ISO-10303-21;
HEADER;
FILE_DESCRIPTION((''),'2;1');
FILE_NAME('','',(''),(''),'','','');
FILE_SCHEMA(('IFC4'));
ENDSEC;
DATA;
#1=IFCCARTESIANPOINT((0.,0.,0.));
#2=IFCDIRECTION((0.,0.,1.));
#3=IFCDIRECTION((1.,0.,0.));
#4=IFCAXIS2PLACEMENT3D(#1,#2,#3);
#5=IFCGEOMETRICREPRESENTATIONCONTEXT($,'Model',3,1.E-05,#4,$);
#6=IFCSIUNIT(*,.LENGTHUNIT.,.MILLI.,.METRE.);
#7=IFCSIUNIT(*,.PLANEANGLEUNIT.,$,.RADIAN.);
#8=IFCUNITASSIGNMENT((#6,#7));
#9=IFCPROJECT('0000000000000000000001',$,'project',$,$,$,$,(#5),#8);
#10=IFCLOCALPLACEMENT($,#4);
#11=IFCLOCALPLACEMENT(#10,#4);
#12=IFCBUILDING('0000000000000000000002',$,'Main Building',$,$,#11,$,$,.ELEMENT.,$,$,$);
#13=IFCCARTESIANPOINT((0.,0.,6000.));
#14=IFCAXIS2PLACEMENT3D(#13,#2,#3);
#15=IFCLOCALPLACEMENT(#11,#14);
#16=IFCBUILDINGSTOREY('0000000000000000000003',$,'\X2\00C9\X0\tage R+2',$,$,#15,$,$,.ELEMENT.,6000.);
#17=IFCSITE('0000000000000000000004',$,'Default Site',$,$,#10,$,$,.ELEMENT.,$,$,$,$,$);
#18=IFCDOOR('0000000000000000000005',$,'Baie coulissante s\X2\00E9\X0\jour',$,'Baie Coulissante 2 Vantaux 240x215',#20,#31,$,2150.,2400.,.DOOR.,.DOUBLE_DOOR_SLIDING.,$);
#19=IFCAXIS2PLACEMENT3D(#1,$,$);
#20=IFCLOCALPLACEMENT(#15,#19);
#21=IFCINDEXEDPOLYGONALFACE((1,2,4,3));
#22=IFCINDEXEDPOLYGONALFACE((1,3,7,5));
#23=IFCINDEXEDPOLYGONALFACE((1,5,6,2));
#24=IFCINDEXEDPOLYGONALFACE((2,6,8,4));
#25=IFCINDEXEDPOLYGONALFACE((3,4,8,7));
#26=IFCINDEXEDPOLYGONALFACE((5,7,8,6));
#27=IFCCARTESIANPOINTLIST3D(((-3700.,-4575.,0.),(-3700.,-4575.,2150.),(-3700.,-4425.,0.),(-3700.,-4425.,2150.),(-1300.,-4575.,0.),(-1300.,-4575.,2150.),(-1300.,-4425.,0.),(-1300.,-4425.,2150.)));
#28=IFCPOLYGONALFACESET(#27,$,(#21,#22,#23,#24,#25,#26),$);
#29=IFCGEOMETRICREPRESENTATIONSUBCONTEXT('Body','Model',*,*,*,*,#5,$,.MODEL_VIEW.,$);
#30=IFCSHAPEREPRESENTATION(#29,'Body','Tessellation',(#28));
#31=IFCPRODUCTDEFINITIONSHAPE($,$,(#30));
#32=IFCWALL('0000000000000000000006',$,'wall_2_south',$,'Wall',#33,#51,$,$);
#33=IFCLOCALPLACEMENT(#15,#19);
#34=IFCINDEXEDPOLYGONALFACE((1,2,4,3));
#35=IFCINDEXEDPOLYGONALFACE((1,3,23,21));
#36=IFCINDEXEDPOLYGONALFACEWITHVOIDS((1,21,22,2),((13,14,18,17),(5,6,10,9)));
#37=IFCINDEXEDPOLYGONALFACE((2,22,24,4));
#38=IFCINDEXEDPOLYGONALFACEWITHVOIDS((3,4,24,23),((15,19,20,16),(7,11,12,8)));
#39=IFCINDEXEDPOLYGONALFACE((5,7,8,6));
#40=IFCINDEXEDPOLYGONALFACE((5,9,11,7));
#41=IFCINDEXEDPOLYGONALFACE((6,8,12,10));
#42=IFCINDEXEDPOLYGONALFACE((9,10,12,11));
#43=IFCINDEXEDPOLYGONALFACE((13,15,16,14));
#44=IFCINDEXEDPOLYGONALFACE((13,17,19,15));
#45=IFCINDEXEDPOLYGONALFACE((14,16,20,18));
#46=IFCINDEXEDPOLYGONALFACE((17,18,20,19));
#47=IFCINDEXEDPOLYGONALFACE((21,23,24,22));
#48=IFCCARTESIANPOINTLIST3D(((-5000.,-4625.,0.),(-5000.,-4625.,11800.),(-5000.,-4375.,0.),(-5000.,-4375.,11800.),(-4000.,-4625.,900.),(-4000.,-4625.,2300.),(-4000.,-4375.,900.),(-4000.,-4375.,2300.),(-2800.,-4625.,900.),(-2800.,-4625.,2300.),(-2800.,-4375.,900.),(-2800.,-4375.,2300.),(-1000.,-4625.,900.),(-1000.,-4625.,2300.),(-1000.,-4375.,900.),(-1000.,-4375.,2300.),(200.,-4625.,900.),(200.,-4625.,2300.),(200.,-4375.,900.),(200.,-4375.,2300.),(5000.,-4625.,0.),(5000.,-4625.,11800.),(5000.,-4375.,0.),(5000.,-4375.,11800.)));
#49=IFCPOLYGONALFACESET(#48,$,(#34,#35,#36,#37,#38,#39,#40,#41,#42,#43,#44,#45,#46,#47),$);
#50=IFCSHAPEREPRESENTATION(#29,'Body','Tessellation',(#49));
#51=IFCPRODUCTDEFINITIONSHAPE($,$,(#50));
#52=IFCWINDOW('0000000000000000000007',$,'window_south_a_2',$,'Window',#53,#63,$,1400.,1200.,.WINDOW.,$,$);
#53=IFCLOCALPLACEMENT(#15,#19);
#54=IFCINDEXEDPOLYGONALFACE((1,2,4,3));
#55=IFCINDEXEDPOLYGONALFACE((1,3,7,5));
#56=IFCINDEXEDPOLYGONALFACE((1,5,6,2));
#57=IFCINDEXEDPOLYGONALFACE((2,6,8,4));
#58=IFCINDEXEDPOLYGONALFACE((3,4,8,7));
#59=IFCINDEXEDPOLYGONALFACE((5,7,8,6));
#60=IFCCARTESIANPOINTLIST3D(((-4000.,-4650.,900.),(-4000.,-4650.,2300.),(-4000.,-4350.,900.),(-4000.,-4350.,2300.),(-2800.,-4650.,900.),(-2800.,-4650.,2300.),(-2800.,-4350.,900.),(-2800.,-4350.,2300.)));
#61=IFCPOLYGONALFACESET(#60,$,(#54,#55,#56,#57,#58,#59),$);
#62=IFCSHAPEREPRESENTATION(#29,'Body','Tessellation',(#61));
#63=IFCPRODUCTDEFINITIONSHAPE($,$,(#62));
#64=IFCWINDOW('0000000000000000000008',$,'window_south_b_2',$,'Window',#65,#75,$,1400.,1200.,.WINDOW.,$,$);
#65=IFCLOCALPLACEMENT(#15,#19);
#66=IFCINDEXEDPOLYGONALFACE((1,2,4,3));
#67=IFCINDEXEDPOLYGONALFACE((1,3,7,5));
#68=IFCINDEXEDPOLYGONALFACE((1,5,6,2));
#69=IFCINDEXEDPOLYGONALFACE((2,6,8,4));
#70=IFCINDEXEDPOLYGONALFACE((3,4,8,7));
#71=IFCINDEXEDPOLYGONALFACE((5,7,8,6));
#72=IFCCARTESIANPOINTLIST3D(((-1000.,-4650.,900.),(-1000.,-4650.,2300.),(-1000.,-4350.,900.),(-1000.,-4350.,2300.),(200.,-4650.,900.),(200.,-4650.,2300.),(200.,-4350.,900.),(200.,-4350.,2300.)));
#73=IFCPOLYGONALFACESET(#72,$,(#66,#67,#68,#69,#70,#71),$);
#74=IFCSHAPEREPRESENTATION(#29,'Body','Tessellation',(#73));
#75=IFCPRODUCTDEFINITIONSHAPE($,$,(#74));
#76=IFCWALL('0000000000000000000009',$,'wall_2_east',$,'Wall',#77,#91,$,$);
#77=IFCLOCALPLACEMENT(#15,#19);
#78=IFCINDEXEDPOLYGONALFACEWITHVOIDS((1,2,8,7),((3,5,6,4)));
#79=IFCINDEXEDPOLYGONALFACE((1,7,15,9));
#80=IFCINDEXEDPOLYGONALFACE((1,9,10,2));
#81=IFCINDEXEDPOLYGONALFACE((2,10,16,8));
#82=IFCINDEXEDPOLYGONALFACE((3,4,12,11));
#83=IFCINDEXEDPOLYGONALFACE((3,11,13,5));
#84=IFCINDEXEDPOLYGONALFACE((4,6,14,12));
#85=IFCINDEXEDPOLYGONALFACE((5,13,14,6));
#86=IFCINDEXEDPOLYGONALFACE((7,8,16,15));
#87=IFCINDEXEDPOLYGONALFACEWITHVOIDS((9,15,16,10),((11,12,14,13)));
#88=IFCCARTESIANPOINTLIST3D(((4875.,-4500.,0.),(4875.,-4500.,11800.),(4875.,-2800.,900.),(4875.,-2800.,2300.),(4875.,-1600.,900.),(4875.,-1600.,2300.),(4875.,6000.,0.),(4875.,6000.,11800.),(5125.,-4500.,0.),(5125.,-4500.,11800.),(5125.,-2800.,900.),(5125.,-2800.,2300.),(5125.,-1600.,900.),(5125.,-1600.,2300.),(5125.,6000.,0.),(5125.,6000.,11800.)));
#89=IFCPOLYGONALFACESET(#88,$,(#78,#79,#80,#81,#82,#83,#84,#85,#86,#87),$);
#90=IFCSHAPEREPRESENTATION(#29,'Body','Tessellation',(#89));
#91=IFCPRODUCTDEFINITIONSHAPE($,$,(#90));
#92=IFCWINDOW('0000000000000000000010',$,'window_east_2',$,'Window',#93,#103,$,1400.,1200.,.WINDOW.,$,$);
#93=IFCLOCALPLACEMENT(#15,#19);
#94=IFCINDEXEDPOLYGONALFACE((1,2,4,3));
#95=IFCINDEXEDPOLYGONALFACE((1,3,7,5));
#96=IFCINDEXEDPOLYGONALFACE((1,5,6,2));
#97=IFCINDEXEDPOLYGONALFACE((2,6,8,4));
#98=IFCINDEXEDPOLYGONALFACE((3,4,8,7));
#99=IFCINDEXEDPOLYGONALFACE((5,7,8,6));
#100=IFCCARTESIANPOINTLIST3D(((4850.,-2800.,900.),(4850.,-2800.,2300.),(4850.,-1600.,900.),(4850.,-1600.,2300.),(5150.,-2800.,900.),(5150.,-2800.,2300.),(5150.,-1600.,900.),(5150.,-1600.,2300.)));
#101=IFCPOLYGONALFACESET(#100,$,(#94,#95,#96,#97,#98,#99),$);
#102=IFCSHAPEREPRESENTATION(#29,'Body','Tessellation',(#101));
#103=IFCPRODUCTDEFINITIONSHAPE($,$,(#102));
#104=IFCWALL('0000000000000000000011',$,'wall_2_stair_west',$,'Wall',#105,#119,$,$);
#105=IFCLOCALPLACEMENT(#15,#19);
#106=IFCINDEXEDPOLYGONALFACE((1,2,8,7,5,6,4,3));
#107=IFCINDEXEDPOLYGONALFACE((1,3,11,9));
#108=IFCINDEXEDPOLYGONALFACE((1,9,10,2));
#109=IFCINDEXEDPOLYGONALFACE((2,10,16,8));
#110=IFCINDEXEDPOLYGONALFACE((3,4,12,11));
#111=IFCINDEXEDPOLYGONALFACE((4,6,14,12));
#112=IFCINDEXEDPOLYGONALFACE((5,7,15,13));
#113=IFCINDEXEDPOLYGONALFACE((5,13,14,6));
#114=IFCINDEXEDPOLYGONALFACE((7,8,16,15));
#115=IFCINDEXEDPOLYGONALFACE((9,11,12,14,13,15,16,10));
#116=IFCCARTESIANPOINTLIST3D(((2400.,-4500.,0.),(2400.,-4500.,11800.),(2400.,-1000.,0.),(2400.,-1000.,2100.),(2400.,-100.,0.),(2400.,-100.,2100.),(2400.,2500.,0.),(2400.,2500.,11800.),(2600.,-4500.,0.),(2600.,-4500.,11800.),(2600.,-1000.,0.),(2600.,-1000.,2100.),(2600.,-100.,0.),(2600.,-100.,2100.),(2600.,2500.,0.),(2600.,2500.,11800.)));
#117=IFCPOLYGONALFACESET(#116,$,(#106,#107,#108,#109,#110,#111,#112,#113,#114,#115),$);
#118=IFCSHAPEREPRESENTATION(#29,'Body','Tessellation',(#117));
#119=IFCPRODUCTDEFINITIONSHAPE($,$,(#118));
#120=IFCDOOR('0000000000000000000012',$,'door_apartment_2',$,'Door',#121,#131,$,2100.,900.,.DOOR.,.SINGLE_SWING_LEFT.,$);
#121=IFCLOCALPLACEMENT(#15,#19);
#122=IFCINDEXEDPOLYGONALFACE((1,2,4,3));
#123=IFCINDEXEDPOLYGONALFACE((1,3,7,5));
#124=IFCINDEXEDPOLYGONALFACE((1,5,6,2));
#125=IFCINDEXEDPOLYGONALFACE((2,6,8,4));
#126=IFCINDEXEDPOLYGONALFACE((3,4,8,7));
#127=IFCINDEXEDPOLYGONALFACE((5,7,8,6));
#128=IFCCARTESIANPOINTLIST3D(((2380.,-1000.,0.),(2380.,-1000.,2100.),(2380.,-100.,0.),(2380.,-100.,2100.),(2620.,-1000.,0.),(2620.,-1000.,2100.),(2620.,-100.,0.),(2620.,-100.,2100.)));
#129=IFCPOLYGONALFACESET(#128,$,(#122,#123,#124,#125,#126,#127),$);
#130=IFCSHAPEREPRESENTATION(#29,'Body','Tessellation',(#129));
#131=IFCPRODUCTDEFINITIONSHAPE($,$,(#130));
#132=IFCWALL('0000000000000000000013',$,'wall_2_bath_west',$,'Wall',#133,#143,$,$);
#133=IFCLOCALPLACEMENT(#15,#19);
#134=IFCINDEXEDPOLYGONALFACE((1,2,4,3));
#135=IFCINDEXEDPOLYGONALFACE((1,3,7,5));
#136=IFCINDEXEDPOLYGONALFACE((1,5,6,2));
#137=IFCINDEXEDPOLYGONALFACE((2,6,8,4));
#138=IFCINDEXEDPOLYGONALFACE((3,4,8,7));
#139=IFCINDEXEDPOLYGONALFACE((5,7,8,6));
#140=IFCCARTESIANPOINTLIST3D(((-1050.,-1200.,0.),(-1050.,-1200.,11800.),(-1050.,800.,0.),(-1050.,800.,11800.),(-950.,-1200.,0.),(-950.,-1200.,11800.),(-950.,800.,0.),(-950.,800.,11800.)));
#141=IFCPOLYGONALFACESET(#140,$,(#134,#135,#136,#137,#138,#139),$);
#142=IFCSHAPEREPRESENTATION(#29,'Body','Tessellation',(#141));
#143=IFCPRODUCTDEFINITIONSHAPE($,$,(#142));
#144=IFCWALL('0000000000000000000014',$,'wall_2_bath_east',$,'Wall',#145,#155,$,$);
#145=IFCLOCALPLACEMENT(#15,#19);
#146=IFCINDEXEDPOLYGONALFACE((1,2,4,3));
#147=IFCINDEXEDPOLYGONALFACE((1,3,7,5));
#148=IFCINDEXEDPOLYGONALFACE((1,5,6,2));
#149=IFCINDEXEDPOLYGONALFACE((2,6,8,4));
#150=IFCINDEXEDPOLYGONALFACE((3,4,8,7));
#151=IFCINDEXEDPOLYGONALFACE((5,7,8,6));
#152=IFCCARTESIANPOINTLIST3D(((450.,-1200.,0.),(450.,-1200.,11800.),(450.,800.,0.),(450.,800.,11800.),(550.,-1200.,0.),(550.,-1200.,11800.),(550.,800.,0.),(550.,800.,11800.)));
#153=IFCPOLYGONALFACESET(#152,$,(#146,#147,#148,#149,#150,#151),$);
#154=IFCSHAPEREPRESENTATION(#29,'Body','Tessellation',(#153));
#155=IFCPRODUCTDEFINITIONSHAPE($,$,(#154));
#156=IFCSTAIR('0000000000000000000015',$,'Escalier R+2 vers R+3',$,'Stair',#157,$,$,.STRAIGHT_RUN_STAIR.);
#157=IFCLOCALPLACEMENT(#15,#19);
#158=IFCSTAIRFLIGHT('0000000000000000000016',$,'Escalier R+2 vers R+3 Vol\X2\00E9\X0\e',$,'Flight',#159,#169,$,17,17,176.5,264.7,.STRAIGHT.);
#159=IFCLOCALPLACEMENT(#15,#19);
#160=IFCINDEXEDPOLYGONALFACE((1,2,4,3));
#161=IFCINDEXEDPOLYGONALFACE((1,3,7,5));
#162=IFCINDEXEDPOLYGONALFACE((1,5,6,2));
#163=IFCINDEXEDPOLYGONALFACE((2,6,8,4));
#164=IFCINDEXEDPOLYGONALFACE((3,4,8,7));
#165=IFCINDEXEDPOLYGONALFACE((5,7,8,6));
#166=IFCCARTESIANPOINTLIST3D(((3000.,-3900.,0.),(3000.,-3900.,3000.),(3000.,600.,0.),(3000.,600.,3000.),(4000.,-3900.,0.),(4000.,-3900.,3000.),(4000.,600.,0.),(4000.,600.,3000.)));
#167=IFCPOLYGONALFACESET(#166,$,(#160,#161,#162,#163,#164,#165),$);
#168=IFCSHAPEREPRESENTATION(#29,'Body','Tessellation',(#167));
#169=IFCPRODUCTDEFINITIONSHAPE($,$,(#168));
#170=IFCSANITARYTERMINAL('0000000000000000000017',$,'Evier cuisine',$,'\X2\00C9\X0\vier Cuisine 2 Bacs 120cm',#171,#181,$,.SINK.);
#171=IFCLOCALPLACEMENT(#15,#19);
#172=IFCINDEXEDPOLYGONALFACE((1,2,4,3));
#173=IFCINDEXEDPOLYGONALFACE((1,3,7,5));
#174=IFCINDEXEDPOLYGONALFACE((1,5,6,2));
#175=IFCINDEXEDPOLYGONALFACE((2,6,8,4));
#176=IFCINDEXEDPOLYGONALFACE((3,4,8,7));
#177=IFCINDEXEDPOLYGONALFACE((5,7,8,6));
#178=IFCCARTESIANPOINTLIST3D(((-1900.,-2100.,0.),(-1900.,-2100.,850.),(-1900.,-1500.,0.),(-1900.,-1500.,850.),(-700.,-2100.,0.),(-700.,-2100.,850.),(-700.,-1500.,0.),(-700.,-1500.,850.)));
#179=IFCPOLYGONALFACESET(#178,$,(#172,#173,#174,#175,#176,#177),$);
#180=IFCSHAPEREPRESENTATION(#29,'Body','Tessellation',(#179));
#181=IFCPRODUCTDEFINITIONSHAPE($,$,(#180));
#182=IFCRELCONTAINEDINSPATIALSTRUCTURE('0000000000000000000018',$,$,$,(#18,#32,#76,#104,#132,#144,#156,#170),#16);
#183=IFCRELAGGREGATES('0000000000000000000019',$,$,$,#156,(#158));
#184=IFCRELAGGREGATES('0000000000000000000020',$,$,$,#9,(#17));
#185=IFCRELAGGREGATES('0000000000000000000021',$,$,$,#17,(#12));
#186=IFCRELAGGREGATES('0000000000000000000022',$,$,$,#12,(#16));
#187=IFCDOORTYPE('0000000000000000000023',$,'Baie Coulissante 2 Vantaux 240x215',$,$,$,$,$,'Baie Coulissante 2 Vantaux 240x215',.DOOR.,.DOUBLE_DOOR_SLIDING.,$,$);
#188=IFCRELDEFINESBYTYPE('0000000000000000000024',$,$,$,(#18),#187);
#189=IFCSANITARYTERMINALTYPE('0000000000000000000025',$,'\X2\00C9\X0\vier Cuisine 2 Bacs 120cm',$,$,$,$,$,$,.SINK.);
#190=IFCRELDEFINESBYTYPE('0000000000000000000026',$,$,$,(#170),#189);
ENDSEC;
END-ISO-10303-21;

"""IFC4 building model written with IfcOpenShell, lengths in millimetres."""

from ifc_helpers import new_model, si_unit, frame, origin_with_axes, place, context, subcontext, project, spatial, polyline, outline, extrude, type_object, element, fill, aggregate, save


model = new_model("IFC4")

# Units and contexts
model_context = context("Model", 3, precision=1e-05, world=origin_with_axes())
body_context = subcontext(model_context, "Body", "Model", "MODEL_VIEW")
ifc_project = project(units=[si_unit("LENGTHUNIT", "METRE", prefix="MILLI"), si_unit("PLANEANGLEUNIT", "RADIAN")], contexts=[model_context])

# Site, building, storey
site_placement = place(None, origin_with_axes())
site = spatial("IfcSite", under=ifc_project, at=site_placement, Name="Default Site", CompositionType="ELEMENT")
building_placement = place(site_placement, origin_with_axes())
building = spatial("IfcBuilding", under=site, at=building_placement, Name="Main Building", CompositionType="ELEMENT")
storey_placement = place(building_placement, frame((0.0, 0.0, 6000.0), z_axis=(0.0, 0.0, 1.0), x_axis=(1.0, 0.0, 0.0)))
storey = spatial("IfcBuildingStorey", under=building, at=storey_placement, Name="Étage R+2", CompositionType="ELEMENT", Elevation=6000.0)

# Door
door_type = type_object("IfcDoorType", Name="Baie Coulissante 2 Vantaux 240x215", ElementType="Baie Coulissante 2 Vantaux 240x215", OperationType="DOUBLE_DOOR_SLIDING", PredefinedType="DOOR")
door_1_placement = place(storey_placement, frame((-2500.0, -4500.0, 0.0), z_axis=(0.0, 0.0, 1.0), x_axis=(1.0, 0.0, 0.0)))
element("IfcDoor", 1, at=door_1_placement, inside=storey, type_object=door_type, Name="Baie coulissante séjour", ObjectType="Baie Coulissante 2 Vantaux 240x215", OperationType="DOUBLE_DOOR_SLIDING", OverallHeight=2150.0, OverallWidth=2400.0, PredefinedType="DOOR", context=body_context, shape_type="SweptSolid", body=[
    extrude(outline(polyline([(-1200.0, -75.0), (1200.0, -75.0), (1200.0, 75.0), (-1200.0, 75.0), (-1200.0, -75.0)])), origin_with_axes(), (0.0, 0.0, 1.0), 2150.0),
])

# Wall, openings, windows
wall_1_placement = place(storey_placement, frame((-5000.0, -4500.0, 0.0), z_axis=(0.0, 0.0, 1.0), x_axis=(1.0, 0.0, 0.0)))
wall_1 = element("IfcWall", 2, at=wall_1_placement, inside=storey, Name="wall_2_south", ObjectType="Wall", context=body_context, shape_type="SweptSolid", body=[
    extrude(outline(polyline([(0.0, -125.0), (10000.0, -125.0), (10000.0, 125.0), (0.0, 125.0), (0.0, -125.0)])), origin_with_axes(), (0.0, 0.0, 1.0), 11800.0),
])
placement_1 = place(wall_1_placement, frame((1000.0, 0.0, 900.0), z_axis=(0.0, 0.0, 1.0), x_axis=(1.0, 0.0, 0.0)))
opening_1 = element("IfcOpeningElement", 3, at=placement_1, cuts=wall_1, PredefinedType="OPENING", context=body_context, shape_type="SweptSolid", body=[
    extrude(outline(polyline([(0.0, -150.0), (1200.0, -150.0), (1200.0, 150.0), (0.0, 150.0), (0.0, -150.0)])), origin_with_axes(), (0.0, 0.0, 1.0), 1400.0),
])
placement_2 = place(wall_1_placement, frame((4000.0, 0.0, 900.0), z_axis=(0.0, 0.0, 1.0), x_axis=(1.0, 0.0, 0.0)))
opening_2 = element("IfcOpeningElement", 4, at=placement_2, cuts=wall_1, PredefinedType="OPENING", context=body_context, shape_type="SweptSolid", body=[
    extrude(outline(polyline([(0.0, -150.0), (1200.0, -150.0), (1200.0, 150.0), (0.0, 150.0), (0.0, -150.0)])), origin_with_axes(), (0.0, 0.0, 1.0), 1400.0),
])
window_1 = element("IfcWindow", 5, at=placement_1, Name="window_south_a_2", ObjectType="Window", OverallHeight=1400.0, OverallWidth=1200.0, PredefinedType="WINDOW", context=body_context, shape_type="SweptSolid", body=[
    extrude(outline(polyline([(0.0, -150.0), (1200.0, -150.0), (1200.0, 150.0), (0.0, 150.0), (0.0, -150.0)])), origin_with_axes(), (0.0, 0.0, 1.0), 1400.0),
])
fill(opening_1, window_1)
window_2 = element("IfcWindow", 6, at=placement_2, Name="window_south_b_2", ObjectType="Window", OverallHeight=1400.0, OverallWidth=1200.0, PredefinedType="WINDOW", context=body_context, shape_type="SweptSolid", body=[
    extrude(outline(polyline([(0.0, -150.0), (1200.0, -150.0), (1200.0, 150.0), (0.0, 150.0), (0.0, -150.0)])), origin_with_axes(), (0.0, 0.0, 1.0), 1400.0),
])
fill(opening_2, window_2)

# Wall, opening, window
wall_2_placement = place(storey_placement, frame((5000.0, -4500.0, 0.0), z_axis=(0.0, 0.0, 1.0), x_axis=(0.0, 1.0, 0.0)))
wall_2 = element("IfcWall", 7, at=wall_2_placement, inside=storey, Name="wall_2_east", ObjectType="Wall", context=body_context, shape_type="SweptSolid", body=[
    extrude(outline(polyline([(0.0, -125.0), (10500.0, -125.0), (10500.0, 125.0), (0.0, 125.0), (0.0, -125.0)])), origin_with_axes(), (0.0, 0.0, 1.0), 11800.0),
])
placement_3 = place(wall_2_placement, frame((1700.0, 0.0, 900.0), z_axis=(0.0, 0.0, 1.0), x_axis=(1.0, 0.0, 0.0)))
opening_3 = element("IfcOpeningElement", 8, at=placement_3, cuts=wall_2, PredefinedType="OPENING", context=body_context, shape_type="SweptSolid", body=[
    extrude(outline(polyline([(0.0, -150.0), (1200.0, -150.0), (1200.0, 150.0), (0.0, 150.0), (0.0, -150.0)])), origin_with_axes(), (0.0, 0.0, 1.0), 1400.0),
])
window_3 = element("IfcWindow", 9, at=placement_3, Name="window_east_2", ObjectType="Window", OverallHeight=1400.0, OverallWidth=1200.0, PredefinedType="WINDOW", context=body_context, shape_type="SweptSolid", body=[
    extrude(outline(polyline([(0.0, -150.0), (1200.0, -150.0), (1200.0, 150.0), (0.0, 150.0), (0.0, -150.0)])), origin_with_axes(), (0.0, 0.0, 1.0), 1400.0),
])
fill(opening_3, window_3)

# Wall, opening, door
wall_3_placement = place(storey_placement, frame((2500.0, -4500.0, 0.0), z_axis=(0.0, 0.0, 1.0), x_axis=(0.0, 1.0, 0.0)))
wall_3 = element("IfcWall", 10, at=wall_3_placement, inside=storey, Name="wall_2_stair_west", ObjectType="Wall", context=body_context, shape_type="SweptSolid", body=[
    extrude(outline(polyline([(0.0, -100.0), (7000.0, -100.0), (7000.0, 100.0), (0.0, 100.0), (0.0, -100.0)])), origin_with_axes(), (0.0, 0.0, 1.0), 11800.0),
])
placement_4 = place(wall_3_placement, frame((3500.0, 0.0, 0.0), z_axis=(0.0, 0.0, 1.0), x_axis=(1.0, 0.0, 0.0)))
opening_4 = element("IfcOpeningElement", 11, at=placement_4, cuts=wall_3, PredefinedType="OPENING", context=body_context, shape_type="SweptSolid", body=[
    extrude(outline(polyline([(0.0, -120.0), (900.0, -120.0), (900.0, 120.0), (0.0, 120.0), (0.0, -120.0)])), origin_with_axes(), (0.0, 0.0, 1.0), 2100.0),
])
door_2 = element("IfcDoor", 12, at=placement_4, Name="door_apartment_2", ObjectType="Door", OperationType="SINGLE_SWING_LEFT", OverallHeight=2100.0, OverallWidth=900.0, PredefinedType="DOOR", context=body_context, shape_type="SweptSolid", body=[
    extrude(outline(polyline([(0.0, -120.0), (900.0, -120.0), (900.0, 120.0), (0.0, 120.0), (0.0, -120.0)])), origin_with_axes(), (0.0, 0.0, 1.0), 2100.0),
])
fill(opening_4, door_2)

# Walls
for number, where, z_axis, x_axis, name in (
    (13, (-1000.0, -1200.0, 0.0), (0.0, 0.0, 1.0), (0.0, 1.0, 0.0), "wall_2_bath_west"),
    (14, (500.0, -1200.0, 0.0), (0.0, 0.0, 1.0), (0.0, 1.0, 0.0), "wall_2_bath_east"),
):
    element("IfcWall", number, at=place(storey_placement, frame(where, z_axis=z_axis, x_axis=x_axis)), inside=storey, Name=name, ObjectType="Wall", context=body_context, shape_type="SweptSolid", body=[
        extrude(outline(polyline([(0.0, -50.0), (2000.0, -50.0), (2000.0, 50.0), (0.0, 50.0), (0.0, -50.0)])), origin_with_axes(), (0.0, 0.0, 1.0), 11800.0),
    ])

# Stair, stair flight
stair_placement = place(storey_placement, frame((3500.0, -3900.0, 0.0), z_axis=(0.0, 0.0, 1.0), x_axis=(0.0, 1.0, 0.0)))
stair = element("IfcStair", 15, at=stair_placement, inside=storey, Name="Escalier R+2 vers R+3", ObjectType="Stair", PredefinedType="STRAIGHT_RUN_STAIR")
stair_flight_placement = place(stair_placement, origin_with_axes())
stair_flight = element("IfcStairFlight", 16, at=stair_flight_placement, Name="Escalier R+2 vers R+3 Volée", ObjectType="Flight", NumberOfRisers=17, NumberOfTreads=17, PredefinedType="STRAIGHT", RiserHeight=176.5, TreadLength=264.7, context=body_context, shape_type="SweptSolid", body=[
    extrude(outline(polyline([(0.0, -500.0), (4500.0, -500.0), (4500.0, 500.0), (0.0, 500.0), (0.0, -500.0)])), origin_with_axes(), (0.0, 0.0, 1.0), 3000.0),
])
aggregate(stair, [stair_flight])

# Sanitary terminal
sanitary_terminal_type = type_object("IfcSanitaryTerminalType", Name="Évier Cuisine 2 Bacs 120cm", PredefinedType="SINK")
sanitary_terminal_placement = place(storey_placement, frame((-1300.0, -1800.0, 0.0), z_axis=(0.0, 0.0, 1.0), x_axis=(1.0, 0.0, 0.0)))
element("IfcSanitaryTerminal", 17, at=sanitary_terminal_placement, inside=storey, type_object=sanitary_terminal_type, Name="Evier cuisine", ObjectType="Évier Cuisine 2 Bacs 120cm", PredefinedType="SINK", context=body_context, shape_type="SweptSolid", body=[
    extrude(outline(polyline([(-600.0, -300.0), (600.0, -300.0), (600.0, 300.0), (-600.0, 300.0), (-600.0, -300.0)])), origin_with_axes(), (0.0, 0.0, 1.0), 850.0),
])

save(model, "model.ifc")
